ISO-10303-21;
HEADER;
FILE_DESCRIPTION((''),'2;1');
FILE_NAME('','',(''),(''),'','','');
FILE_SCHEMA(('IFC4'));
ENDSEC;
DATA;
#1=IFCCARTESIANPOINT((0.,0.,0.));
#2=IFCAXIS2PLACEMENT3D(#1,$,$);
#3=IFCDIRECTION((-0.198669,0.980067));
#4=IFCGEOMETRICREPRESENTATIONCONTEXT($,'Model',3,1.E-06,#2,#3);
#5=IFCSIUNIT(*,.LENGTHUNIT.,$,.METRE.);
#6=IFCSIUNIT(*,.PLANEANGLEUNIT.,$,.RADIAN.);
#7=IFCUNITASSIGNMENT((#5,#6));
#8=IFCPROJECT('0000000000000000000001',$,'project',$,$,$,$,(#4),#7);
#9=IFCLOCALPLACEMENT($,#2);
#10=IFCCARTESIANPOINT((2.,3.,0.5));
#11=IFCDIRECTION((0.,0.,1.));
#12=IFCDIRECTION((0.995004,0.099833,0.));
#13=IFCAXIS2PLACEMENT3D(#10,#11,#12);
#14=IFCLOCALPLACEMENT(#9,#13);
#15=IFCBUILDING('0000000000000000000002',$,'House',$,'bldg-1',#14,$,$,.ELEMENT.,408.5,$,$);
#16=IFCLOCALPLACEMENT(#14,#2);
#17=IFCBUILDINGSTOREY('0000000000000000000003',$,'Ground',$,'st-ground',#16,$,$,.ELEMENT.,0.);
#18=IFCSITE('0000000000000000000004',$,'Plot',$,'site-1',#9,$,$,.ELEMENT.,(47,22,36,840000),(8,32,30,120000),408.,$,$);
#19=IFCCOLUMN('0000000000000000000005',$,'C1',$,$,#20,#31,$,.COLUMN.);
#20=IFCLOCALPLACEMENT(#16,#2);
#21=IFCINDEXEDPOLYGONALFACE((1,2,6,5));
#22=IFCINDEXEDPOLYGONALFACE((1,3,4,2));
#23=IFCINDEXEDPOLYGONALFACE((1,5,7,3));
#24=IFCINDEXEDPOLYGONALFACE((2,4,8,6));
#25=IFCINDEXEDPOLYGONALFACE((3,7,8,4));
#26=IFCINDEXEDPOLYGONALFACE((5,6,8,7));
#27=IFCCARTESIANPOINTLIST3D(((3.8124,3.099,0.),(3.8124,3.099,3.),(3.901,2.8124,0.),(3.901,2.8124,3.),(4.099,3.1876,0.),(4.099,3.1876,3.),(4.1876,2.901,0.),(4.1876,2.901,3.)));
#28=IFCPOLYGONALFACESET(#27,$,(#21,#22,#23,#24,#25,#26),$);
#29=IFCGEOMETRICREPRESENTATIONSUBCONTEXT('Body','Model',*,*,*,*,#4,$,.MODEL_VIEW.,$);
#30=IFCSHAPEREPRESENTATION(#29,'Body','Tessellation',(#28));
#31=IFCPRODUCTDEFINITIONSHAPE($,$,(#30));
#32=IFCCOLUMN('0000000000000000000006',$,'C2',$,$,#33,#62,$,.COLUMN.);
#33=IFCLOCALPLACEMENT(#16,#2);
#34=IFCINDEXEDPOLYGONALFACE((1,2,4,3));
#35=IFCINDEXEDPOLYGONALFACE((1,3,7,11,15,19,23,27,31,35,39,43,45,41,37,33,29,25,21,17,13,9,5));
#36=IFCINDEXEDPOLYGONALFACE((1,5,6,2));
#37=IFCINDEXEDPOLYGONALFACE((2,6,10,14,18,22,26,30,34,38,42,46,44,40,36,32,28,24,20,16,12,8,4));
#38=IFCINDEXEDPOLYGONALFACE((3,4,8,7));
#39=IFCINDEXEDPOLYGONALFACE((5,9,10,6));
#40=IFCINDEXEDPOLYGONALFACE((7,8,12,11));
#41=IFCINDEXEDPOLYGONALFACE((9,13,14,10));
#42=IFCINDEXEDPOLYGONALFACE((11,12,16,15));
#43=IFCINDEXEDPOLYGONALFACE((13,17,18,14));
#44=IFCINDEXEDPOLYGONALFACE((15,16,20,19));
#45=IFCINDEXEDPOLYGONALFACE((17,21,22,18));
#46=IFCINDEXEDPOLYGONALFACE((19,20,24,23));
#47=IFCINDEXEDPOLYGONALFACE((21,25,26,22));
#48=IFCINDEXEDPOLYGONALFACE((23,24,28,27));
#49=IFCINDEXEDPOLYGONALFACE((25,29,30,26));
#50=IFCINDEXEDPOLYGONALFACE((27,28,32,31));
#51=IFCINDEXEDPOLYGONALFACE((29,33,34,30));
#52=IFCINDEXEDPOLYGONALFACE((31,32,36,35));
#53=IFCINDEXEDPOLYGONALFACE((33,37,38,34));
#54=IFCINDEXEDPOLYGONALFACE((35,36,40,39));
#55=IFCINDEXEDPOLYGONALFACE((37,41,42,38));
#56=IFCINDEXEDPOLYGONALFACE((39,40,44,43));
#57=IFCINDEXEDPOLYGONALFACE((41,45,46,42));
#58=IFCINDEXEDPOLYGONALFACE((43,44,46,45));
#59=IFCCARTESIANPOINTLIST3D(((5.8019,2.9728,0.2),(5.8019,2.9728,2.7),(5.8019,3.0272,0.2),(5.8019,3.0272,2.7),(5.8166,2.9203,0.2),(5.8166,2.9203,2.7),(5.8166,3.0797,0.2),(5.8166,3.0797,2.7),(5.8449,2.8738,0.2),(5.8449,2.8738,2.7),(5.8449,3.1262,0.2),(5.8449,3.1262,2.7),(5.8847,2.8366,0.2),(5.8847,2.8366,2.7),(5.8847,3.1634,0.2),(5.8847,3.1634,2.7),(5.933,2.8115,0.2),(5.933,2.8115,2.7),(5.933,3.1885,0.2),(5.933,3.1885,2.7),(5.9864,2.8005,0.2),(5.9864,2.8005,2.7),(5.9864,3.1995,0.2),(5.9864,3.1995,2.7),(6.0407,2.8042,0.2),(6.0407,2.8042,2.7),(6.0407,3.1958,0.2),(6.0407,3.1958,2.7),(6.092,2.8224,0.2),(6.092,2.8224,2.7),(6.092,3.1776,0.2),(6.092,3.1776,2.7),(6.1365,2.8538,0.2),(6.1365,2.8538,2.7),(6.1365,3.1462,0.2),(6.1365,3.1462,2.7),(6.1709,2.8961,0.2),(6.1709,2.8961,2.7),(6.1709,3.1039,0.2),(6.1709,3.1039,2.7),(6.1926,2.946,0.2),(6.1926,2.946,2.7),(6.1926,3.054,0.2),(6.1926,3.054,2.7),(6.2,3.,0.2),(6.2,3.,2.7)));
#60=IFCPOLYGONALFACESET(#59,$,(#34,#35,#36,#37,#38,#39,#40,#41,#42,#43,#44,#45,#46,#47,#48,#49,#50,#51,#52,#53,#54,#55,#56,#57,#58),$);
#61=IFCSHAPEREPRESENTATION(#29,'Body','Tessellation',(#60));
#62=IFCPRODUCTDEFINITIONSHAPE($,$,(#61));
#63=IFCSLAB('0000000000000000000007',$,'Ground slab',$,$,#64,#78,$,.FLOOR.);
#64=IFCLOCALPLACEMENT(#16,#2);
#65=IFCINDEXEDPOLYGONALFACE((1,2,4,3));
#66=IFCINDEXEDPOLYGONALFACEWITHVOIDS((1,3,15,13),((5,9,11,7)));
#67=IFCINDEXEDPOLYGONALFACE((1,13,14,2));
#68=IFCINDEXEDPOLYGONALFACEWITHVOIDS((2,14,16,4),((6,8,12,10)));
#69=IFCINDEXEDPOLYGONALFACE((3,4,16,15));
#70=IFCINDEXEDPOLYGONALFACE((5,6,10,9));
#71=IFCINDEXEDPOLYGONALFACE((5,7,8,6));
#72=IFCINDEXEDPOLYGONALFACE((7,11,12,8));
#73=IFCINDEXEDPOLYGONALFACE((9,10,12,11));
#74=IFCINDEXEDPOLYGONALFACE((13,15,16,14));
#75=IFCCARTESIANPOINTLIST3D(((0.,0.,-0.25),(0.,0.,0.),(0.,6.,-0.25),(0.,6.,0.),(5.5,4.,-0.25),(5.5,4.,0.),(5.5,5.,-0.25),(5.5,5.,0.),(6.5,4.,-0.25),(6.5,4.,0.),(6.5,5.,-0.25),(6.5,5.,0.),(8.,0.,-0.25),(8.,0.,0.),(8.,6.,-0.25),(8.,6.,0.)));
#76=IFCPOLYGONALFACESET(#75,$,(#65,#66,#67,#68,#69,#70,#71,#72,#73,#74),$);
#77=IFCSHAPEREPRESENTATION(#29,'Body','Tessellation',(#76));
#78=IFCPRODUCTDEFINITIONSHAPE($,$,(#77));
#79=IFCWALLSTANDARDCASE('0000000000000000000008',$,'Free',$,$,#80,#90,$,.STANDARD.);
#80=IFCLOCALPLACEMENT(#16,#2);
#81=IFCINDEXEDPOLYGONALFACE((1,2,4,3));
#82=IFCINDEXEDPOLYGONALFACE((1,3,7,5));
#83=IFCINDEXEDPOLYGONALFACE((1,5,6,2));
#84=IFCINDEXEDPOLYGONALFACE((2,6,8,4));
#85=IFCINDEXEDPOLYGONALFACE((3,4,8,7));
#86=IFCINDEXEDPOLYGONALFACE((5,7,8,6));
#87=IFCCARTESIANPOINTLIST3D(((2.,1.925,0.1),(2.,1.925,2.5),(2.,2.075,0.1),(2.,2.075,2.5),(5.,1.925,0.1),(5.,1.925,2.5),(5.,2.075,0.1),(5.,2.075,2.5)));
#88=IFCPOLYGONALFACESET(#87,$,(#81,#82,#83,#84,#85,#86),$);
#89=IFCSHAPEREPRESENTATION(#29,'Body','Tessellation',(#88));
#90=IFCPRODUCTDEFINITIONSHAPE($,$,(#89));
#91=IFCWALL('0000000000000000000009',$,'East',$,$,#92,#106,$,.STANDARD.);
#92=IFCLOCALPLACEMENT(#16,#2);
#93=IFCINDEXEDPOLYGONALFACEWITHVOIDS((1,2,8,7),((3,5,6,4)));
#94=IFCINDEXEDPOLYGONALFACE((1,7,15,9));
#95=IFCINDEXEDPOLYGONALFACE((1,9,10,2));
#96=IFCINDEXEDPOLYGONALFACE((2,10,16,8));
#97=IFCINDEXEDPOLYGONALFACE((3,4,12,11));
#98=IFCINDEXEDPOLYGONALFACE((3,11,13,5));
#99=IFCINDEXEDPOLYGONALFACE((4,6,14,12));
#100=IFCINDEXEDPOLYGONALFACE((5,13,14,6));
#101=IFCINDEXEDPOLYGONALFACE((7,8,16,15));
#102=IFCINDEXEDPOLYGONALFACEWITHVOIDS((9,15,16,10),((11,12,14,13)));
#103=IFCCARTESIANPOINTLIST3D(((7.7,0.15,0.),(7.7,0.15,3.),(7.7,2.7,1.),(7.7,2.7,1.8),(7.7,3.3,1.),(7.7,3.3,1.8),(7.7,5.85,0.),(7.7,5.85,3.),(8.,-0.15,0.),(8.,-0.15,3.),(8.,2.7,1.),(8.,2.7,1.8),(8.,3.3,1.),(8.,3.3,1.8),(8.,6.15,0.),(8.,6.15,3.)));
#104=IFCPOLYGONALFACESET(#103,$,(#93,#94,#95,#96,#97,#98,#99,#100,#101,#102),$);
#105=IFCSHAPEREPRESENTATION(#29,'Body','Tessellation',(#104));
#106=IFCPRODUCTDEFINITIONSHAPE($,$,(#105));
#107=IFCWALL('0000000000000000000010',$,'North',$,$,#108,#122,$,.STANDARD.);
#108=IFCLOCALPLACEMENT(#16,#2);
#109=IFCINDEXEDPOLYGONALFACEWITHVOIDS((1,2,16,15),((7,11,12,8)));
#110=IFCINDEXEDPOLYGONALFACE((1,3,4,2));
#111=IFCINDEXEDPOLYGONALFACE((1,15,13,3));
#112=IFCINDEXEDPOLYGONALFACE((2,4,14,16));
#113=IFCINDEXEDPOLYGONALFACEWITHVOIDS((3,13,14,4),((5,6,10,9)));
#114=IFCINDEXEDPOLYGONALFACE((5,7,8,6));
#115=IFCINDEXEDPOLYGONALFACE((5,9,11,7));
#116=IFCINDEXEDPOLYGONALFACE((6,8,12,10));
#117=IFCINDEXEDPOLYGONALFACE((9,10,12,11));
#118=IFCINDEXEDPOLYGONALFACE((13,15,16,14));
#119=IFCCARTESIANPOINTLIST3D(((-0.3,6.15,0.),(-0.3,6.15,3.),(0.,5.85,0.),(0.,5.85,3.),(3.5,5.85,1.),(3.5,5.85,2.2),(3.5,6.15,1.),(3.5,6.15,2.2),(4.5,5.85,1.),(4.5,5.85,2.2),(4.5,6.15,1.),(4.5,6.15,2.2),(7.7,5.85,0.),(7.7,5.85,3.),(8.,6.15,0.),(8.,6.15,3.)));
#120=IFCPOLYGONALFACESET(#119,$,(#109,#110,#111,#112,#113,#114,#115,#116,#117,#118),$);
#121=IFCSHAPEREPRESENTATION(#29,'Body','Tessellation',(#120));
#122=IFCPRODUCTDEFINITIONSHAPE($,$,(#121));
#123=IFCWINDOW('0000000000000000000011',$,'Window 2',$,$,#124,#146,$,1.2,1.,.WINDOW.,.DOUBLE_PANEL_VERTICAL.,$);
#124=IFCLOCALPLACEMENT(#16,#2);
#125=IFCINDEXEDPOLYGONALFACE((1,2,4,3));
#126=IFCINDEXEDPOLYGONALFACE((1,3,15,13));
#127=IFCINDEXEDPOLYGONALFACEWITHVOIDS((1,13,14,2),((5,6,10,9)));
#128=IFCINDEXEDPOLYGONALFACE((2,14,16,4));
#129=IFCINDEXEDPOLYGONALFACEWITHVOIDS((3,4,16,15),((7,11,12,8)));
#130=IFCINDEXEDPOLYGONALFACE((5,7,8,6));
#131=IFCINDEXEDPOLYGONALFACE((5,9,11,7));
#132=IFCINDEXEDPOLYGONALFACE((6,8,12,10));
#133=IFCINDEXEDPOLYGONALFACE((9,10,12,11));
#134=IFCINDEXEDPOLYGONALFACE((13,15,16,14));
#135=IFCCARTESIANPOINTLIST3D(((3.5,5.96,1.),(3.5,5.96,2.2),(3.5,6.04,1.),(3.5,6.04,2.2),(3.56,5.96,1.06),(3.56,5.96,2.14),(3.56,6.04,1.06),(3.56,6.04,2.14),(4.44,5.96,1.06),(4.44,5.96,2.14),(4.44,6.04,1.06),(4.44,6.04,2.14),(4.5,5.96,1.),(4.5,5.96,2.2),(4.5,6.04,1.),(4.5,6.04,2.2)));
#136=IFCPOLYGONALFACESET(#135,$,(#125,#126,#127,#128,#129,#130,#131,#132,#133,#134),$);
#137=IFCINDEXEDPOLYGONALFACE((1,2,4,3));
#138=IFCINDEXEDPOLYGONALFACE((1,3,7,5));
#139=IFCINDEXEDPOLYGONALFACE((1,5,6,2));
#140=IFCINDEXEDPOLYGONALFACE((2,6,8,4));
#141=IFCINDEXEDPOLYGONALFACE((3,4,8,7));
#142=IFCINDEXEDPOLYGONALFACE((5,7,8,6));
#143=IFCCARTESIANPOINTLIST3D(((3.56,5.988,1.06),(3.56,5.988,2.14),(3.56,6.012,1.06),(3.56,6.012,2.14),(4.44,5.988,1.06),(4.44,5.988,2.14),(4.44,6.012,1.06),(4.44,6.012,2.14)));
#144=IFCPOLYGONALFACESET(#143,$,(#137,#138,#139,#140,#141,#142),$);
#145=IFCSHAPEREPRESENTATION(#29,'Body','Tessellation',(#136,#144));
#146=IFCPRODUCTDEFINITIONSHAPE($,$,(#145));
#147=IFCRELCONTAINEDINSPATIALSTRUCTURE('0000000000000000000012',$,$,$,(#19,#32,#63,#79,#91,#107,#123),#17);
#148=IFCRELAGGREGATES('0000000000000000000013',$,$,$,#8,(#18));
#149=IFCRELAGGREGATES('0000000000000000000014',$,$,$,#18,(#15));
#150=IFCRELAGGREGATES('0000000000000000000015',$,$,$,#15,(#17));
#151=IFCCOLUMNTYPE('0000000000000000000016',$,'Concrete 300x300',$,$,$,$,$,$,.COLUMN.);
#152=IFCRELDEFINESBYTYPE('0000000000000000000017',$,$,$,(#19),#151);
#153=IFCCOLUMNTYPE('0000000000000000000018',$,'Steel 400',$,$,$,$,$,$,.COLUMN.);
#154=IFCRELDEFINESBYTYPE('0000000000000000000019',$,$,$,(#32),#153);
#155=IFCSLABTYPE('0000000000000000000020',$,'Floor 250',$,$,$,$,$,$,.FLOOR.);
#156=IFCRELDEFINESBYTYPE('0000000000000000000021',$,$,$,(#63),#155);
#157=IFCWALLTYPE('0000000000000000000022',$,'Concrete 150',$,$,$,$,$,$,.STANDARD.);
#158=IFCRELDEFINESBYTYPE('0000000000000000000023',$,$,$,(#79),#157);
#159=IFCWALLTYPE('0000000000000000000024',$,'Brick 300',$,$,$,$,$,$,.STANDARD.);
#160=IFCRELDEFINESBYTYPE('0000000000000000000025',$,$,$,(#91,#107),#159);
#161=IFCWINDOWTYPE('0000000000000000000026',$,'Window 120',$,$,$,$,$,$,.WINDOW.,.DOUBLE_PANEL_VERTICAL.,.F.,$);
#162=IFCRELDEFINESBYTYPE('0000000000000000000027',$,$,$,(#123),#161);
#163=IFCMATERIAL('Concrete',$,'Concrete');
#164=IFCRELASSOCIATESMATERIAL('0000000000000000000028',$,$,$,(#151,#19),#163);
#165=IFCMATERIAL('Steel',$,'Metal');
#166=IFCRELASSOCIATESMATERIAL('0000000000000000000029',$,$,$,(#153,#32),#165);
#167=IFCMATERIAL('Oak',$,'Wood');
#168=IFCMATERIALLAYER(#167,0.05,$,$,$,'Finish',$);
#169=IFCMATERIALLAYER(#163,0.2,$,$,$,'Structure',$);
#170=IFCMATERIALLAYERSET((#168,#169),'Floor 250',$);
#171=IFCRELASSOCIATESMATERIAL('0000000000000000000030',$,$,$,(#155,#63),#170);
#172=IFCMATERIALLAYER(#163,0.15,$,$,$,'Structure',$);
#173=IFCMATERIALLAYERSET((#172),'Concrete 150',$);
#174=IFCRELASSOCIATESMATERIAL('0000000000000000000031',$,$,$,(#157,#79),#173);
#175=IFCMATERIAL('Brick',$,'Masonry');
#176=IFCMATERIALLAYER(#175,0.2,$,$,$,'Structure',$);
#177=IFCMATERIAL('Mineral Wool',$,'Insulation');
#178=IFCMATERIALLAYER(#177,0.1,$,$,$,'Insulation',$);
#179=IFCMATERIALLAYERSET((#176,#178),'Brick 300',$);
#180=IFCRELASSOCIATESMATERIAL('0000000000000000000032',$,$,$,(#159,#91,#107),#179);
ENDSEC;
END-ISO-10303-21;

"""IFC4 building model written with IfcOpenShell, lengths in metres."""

from ifc_helpers import new_model, si_unit, direction, frame, frame_2d, origin, origin_2d, place, context, subcontext, project, spatial, polyline, rectangle, circle, outline, extrude, material, layer, layer_set, layer_usage, type_object, element, fill, save


model = new_model("IFC4")

# Units and contexts
model_context = context("Model", 3, precision=1e-06, world=origin(), true_north=direction((-0.198669, 0.980067)))
body_context = subcontext(model_context, "Body", "Model", "MODEL_VIEW")
ifc_project = project(units=[si_unit("LENGTHUNIT", "METRE"), si_unit("PLANEANGLEUNIT", "RADIAN")], contexts=[model_context])

# Site, building, storey
site_placement = place(None, origin())
site = spatial("IfcSite", under=ifc_project, at=site_placement, Name="Plot", ObjectType="site-1", CompositionType="ELEMENT", RefLatitude=(47, 22, 36, 840000), RefLongitude=(8, 32, 30, 120000), RefElevation=408.0)
building_placement = place(site_placement, frame((2.0, 3.0, 0.5), z_axis=(0.0, 0.0, 1.0), x_axis=(0.995004, 0.099833, 0.0)))
building = spatial("IfcBuilding", under=site, at=building_placement, Name="House", ObjectType="bldg-1", CompositionType="ELEMENT", ElevationOfRefHeight=408.5)
storey_placement = place(building_placement, origin())
storey = spatial("IfcBuildingStorey", under=building, at=storey_placement, Name="Ground", ObjectType="st-ground", CompositionType="ELEMENT", Elevation=0.0)

# Columns
ifc_material_1 = material(Name="Concrete", Category="Concrete")
column_type_1 = type_object("IfcColumnType", Name="Concrete 300x300", PredefinedType="COLUMN", material=ifc_material_1)
column_1_placement = place(storey_placement, frame((4.0, 3.0, 0.0), z_axis=(0.0, 0.0, 1.0), x_axis=(0.955336, 0.29552, 0.0)))
element("IfcColumn", 1, at=column_1_placement, inside=storey, type_object=column_type_1, material=ifc_material_1, Name="C1", PredefinedType="COLUMN", context=body_context, shape_type="SweptSolid", body=[
    extrude(rectangle(XDim=0.3, YDim=0.3, at=origin_2d()), origin(), (0.0, 0.0, 1.0), 3.0),
])
ifc_material_2 = material(Name="Steel", Category="Metal")
column_type_2 = type_object("IfcColumnType", Name="Steel 400", PredefinedType="COLUMN", material=ifc_material_2)
column_2_placement = place(storey_placement, frame((6.0, 3.0, 0.2)))
element("IfcColumn", 2, at=column_2_placement, inside=storey, type_object=column_type_2, material=ifc_material_2, Name="C2", PredefinedType="COLUMN", context=body_context, shape_type="SweptSolid", body=[
    extrude(circle(Radius=0.2, at=origin_2d()), origin(), (0.0, 0.0, 1.0), 2.5),
])

# Slab
ifc_material_3 = material(Name="Oak", Category="Wood")
ifc_layer_1 = layer(ifc_material_3, 0.05, Category="Finish")
ifc_layer_2 = layer(ifc_material_1, 0.2, Category="Structure")
ifc_layer_set_1 = layer_set([ifc_layer_1, ifc_layer_2], Name="Floor 250")
ifc_layer_usage_1 = layer_usage(ifc_layer_set_1, "AXIS3", "NEGATIVE", 0.25)
slab_type = type_object("IfcSlabType", Name="Floor 250", PredefinedType="FLOOR", material=ifc_layer_set_1)
slab_placement = place(storey_placement, frame((0.0, 0.0, -0.25)))
element("IfcSlab", 3, at=slab_placement, inside=storey, type_object=slab_type, material=ifc_layer_usage_1, Name="Ground slab", PredefinedType="FLOOR", context=body_context, shape_type="SweptSolid", body=[
    extrude(outline(polyline([(0.0, 0.0), (8.0, 0.0), (8.0, 6.0), (0.0, 6.0), (0.0, 0.0)]), holes=[polyline([(5.5, 4.0), (5.5, 5.0), (6.5, 5.0), (6.5, 4.0), (5.5, 4.0)])]), origin(), (0.0, 0.0, 1.0), 0.25),
])

# Shared definitions
ifc_layer_3 = layer(ifc_material_1, 0.15, Category="Structure")
ifc_layer_set_2 = layer_set([ifc_layer_3], Name="Concrete 150")
wall_type_1 = type_object("IfcWallType", Name="Concrete 150", PredefinedType="STANDARD", material=ifc_layer_set_2)
window_type = type_object("IfcWindowType", Name="Window 120", ParameterTakesPrecedence=False, PartitioningType="DOUBLE_PANEL_VERTICAL", PredefinedType="WINDOW")

# Wall
ifc_layer_usage_2 = layer_usage(ifc_layer_set_2, "AXIS2", "NEGATIVE", 0.075)
wall_1_placement = place(storey_placement, frame((2.0, 2.0, 0.1), z_axis=(0.0, 0.0, 1.0), x_axis=(1.0, 0.0, 0.0)))
element("IfcWallStandardCase", 4, at=wall_1_placement, inside=storey, type_object=wall_type_1, material=ifc_layer_usage_2, Name="Free", PredefinedType="STANDARD", context=body_context, shape_type="SweptSolid", body=[
    extrude(rectangle(XDim=3.0, YDim=0.15, at=frame_2d((1.5, 0.0))), origin(), (0.0, 0.0, 1.0), 2.4),
])

# Wall, opening
ifc_material_4 = material(Name="Brick", Category="Masonry")
ifc_layer_4 = layer(ifc_material_4, 0.2, Category="Structure")
ifc_material_5 = material(Name="Mineral Wool", Category="Insulation")
ifc_layer_5 = layer(ifc_material_5, 0.1, Category="Insulation")
ifc_layer_set_3 = layer_set([ifc_layer_4, ifc_layer_5], Name="Brick 300")
ifc_layer_usage_3 = layer_usage(ifc_layer_set_3, "AXIS2", "NEGATIVE", 0.3)
wall_type_2 = type_object("IfcWallType", Name="Brick 300", PredefinedType="STANDARD", material=ifc_layer_set_3)
wall_2_placement = place(storey_placement, origin())
wall_2 = element("IfcWall", 5, at=wall_2_placement, inside=storey, type_object=wall_type_2, material=ifc_layer_usage_3, Name="East", PredefinedType="STANDARD", context=body_context, shape_type="SweptSolid", body=[
    extrude(outline(polyline([(8.0, -0.15), (8.0, 6.15), (7.7, 5.85), (7.7, 0.15), (8.0, -0.15)])), origin(), (0.0, 0.0, 1.0), 3.0),
])
opening_1_placement = place(wall_2_placement, frame((7.85, 3.0, 1.0), z_axis=(0.0, 0.0, 1.0), x_axis=(0.0, 1.0, 0.0)))
element("IfcOpeningElement", 6, at=opening_1_placement, cuts=wall_2, PredefinedType="OPENING", context=body_context, shape_type="SweptSolid", body=[
    extrude(rectangle(XDim=0.6, YDim=0.3, at=origin_2d()), origin(), (0.0, 0.0, 1.0), 0.8),
])

# Wall, opening, window
ifc_layer_usage_4 = layer_usage(ifc_layer_set_3, "AXIS2", "NEGATIVE", 0.15)
wall_3_placement = place(storey_placement, origin())
wall_3 = element("IfcWall", 7, at=wall_3_placement, inside=storey, type_object=wall_type_2, material=ifc_layer_usage_4, Name="North", PredefinedType="STANDARD", context=body_context, shape_type="SweptSolid", body=[
    extrude(outline(polyline([(8.0, 6.15), (-0.3, 6.15), (0.0, 5.85), (7.7, 5.85), (8.0, 6.15)])), origin(), (0.0, 0.0, 1.0), 3.0),
])
opening_2_placement = place(wall_3_placement, frame((4.0, 6.0, 1.0), z_axis=(0.0, 0.0, 1.0), x_axis=(-1.0, 0.0, 0.0)))
opening_2 = element("IfcOpeningElement", 8, at=opening_2_placement, cuts=wall_3, PredefinedType="OPENING", context=body_context, shape_type="SweptSolid", body=[
    extrude(rectangle(XDim=1.0, YDim=0.3, at=origin_2d()), origin(), (0.0, 0.0, 1.0), 1.2),
])
window_1_placement = place(opening_2_placement, frame((0.0, 0.0, 0.0), z_axis=(0.0, 1.0, 0.0), x_axis=(-1.0, 0.0, 0.0)))
window_1 = element("IfcWindow", 9, at=window_1_placement, inside=storey, type_object=window_type, Name="Window 2", OverallHeight=1.2, OverallWidth=1.0, PartitioningType="DOUBLE_PANEL_VERTICAL", PredefinedType="WINDOW", context=body_context, shape_type="SweptSolid", body=[
    extrude(outline(polyline([(-0.5, 0.0), (0.5, 0.0), (0.5, 1.2), (-0.5, 1.2), (-0.5, 0.0)]), holes=[polyline([(-0.44, 0.06), (0.44, 0.06), (0.44, 1.14), (-0.44, 1.14), (-0.44, 0.06)])]), frame((0.0, 0.0, -0.04)), (0.0, 0.0, 1.0), 0.08),
    extrude(rectangle(XDim=0.88, YDim=1.08, at=frame_2d((0.0, 0.6))), frame((0.0, 0.0, -0.012)), (0.0, 0.0, 1.0), 0.024),
])
fill(opening_2, window_1)

save(model, "model.ifc")
